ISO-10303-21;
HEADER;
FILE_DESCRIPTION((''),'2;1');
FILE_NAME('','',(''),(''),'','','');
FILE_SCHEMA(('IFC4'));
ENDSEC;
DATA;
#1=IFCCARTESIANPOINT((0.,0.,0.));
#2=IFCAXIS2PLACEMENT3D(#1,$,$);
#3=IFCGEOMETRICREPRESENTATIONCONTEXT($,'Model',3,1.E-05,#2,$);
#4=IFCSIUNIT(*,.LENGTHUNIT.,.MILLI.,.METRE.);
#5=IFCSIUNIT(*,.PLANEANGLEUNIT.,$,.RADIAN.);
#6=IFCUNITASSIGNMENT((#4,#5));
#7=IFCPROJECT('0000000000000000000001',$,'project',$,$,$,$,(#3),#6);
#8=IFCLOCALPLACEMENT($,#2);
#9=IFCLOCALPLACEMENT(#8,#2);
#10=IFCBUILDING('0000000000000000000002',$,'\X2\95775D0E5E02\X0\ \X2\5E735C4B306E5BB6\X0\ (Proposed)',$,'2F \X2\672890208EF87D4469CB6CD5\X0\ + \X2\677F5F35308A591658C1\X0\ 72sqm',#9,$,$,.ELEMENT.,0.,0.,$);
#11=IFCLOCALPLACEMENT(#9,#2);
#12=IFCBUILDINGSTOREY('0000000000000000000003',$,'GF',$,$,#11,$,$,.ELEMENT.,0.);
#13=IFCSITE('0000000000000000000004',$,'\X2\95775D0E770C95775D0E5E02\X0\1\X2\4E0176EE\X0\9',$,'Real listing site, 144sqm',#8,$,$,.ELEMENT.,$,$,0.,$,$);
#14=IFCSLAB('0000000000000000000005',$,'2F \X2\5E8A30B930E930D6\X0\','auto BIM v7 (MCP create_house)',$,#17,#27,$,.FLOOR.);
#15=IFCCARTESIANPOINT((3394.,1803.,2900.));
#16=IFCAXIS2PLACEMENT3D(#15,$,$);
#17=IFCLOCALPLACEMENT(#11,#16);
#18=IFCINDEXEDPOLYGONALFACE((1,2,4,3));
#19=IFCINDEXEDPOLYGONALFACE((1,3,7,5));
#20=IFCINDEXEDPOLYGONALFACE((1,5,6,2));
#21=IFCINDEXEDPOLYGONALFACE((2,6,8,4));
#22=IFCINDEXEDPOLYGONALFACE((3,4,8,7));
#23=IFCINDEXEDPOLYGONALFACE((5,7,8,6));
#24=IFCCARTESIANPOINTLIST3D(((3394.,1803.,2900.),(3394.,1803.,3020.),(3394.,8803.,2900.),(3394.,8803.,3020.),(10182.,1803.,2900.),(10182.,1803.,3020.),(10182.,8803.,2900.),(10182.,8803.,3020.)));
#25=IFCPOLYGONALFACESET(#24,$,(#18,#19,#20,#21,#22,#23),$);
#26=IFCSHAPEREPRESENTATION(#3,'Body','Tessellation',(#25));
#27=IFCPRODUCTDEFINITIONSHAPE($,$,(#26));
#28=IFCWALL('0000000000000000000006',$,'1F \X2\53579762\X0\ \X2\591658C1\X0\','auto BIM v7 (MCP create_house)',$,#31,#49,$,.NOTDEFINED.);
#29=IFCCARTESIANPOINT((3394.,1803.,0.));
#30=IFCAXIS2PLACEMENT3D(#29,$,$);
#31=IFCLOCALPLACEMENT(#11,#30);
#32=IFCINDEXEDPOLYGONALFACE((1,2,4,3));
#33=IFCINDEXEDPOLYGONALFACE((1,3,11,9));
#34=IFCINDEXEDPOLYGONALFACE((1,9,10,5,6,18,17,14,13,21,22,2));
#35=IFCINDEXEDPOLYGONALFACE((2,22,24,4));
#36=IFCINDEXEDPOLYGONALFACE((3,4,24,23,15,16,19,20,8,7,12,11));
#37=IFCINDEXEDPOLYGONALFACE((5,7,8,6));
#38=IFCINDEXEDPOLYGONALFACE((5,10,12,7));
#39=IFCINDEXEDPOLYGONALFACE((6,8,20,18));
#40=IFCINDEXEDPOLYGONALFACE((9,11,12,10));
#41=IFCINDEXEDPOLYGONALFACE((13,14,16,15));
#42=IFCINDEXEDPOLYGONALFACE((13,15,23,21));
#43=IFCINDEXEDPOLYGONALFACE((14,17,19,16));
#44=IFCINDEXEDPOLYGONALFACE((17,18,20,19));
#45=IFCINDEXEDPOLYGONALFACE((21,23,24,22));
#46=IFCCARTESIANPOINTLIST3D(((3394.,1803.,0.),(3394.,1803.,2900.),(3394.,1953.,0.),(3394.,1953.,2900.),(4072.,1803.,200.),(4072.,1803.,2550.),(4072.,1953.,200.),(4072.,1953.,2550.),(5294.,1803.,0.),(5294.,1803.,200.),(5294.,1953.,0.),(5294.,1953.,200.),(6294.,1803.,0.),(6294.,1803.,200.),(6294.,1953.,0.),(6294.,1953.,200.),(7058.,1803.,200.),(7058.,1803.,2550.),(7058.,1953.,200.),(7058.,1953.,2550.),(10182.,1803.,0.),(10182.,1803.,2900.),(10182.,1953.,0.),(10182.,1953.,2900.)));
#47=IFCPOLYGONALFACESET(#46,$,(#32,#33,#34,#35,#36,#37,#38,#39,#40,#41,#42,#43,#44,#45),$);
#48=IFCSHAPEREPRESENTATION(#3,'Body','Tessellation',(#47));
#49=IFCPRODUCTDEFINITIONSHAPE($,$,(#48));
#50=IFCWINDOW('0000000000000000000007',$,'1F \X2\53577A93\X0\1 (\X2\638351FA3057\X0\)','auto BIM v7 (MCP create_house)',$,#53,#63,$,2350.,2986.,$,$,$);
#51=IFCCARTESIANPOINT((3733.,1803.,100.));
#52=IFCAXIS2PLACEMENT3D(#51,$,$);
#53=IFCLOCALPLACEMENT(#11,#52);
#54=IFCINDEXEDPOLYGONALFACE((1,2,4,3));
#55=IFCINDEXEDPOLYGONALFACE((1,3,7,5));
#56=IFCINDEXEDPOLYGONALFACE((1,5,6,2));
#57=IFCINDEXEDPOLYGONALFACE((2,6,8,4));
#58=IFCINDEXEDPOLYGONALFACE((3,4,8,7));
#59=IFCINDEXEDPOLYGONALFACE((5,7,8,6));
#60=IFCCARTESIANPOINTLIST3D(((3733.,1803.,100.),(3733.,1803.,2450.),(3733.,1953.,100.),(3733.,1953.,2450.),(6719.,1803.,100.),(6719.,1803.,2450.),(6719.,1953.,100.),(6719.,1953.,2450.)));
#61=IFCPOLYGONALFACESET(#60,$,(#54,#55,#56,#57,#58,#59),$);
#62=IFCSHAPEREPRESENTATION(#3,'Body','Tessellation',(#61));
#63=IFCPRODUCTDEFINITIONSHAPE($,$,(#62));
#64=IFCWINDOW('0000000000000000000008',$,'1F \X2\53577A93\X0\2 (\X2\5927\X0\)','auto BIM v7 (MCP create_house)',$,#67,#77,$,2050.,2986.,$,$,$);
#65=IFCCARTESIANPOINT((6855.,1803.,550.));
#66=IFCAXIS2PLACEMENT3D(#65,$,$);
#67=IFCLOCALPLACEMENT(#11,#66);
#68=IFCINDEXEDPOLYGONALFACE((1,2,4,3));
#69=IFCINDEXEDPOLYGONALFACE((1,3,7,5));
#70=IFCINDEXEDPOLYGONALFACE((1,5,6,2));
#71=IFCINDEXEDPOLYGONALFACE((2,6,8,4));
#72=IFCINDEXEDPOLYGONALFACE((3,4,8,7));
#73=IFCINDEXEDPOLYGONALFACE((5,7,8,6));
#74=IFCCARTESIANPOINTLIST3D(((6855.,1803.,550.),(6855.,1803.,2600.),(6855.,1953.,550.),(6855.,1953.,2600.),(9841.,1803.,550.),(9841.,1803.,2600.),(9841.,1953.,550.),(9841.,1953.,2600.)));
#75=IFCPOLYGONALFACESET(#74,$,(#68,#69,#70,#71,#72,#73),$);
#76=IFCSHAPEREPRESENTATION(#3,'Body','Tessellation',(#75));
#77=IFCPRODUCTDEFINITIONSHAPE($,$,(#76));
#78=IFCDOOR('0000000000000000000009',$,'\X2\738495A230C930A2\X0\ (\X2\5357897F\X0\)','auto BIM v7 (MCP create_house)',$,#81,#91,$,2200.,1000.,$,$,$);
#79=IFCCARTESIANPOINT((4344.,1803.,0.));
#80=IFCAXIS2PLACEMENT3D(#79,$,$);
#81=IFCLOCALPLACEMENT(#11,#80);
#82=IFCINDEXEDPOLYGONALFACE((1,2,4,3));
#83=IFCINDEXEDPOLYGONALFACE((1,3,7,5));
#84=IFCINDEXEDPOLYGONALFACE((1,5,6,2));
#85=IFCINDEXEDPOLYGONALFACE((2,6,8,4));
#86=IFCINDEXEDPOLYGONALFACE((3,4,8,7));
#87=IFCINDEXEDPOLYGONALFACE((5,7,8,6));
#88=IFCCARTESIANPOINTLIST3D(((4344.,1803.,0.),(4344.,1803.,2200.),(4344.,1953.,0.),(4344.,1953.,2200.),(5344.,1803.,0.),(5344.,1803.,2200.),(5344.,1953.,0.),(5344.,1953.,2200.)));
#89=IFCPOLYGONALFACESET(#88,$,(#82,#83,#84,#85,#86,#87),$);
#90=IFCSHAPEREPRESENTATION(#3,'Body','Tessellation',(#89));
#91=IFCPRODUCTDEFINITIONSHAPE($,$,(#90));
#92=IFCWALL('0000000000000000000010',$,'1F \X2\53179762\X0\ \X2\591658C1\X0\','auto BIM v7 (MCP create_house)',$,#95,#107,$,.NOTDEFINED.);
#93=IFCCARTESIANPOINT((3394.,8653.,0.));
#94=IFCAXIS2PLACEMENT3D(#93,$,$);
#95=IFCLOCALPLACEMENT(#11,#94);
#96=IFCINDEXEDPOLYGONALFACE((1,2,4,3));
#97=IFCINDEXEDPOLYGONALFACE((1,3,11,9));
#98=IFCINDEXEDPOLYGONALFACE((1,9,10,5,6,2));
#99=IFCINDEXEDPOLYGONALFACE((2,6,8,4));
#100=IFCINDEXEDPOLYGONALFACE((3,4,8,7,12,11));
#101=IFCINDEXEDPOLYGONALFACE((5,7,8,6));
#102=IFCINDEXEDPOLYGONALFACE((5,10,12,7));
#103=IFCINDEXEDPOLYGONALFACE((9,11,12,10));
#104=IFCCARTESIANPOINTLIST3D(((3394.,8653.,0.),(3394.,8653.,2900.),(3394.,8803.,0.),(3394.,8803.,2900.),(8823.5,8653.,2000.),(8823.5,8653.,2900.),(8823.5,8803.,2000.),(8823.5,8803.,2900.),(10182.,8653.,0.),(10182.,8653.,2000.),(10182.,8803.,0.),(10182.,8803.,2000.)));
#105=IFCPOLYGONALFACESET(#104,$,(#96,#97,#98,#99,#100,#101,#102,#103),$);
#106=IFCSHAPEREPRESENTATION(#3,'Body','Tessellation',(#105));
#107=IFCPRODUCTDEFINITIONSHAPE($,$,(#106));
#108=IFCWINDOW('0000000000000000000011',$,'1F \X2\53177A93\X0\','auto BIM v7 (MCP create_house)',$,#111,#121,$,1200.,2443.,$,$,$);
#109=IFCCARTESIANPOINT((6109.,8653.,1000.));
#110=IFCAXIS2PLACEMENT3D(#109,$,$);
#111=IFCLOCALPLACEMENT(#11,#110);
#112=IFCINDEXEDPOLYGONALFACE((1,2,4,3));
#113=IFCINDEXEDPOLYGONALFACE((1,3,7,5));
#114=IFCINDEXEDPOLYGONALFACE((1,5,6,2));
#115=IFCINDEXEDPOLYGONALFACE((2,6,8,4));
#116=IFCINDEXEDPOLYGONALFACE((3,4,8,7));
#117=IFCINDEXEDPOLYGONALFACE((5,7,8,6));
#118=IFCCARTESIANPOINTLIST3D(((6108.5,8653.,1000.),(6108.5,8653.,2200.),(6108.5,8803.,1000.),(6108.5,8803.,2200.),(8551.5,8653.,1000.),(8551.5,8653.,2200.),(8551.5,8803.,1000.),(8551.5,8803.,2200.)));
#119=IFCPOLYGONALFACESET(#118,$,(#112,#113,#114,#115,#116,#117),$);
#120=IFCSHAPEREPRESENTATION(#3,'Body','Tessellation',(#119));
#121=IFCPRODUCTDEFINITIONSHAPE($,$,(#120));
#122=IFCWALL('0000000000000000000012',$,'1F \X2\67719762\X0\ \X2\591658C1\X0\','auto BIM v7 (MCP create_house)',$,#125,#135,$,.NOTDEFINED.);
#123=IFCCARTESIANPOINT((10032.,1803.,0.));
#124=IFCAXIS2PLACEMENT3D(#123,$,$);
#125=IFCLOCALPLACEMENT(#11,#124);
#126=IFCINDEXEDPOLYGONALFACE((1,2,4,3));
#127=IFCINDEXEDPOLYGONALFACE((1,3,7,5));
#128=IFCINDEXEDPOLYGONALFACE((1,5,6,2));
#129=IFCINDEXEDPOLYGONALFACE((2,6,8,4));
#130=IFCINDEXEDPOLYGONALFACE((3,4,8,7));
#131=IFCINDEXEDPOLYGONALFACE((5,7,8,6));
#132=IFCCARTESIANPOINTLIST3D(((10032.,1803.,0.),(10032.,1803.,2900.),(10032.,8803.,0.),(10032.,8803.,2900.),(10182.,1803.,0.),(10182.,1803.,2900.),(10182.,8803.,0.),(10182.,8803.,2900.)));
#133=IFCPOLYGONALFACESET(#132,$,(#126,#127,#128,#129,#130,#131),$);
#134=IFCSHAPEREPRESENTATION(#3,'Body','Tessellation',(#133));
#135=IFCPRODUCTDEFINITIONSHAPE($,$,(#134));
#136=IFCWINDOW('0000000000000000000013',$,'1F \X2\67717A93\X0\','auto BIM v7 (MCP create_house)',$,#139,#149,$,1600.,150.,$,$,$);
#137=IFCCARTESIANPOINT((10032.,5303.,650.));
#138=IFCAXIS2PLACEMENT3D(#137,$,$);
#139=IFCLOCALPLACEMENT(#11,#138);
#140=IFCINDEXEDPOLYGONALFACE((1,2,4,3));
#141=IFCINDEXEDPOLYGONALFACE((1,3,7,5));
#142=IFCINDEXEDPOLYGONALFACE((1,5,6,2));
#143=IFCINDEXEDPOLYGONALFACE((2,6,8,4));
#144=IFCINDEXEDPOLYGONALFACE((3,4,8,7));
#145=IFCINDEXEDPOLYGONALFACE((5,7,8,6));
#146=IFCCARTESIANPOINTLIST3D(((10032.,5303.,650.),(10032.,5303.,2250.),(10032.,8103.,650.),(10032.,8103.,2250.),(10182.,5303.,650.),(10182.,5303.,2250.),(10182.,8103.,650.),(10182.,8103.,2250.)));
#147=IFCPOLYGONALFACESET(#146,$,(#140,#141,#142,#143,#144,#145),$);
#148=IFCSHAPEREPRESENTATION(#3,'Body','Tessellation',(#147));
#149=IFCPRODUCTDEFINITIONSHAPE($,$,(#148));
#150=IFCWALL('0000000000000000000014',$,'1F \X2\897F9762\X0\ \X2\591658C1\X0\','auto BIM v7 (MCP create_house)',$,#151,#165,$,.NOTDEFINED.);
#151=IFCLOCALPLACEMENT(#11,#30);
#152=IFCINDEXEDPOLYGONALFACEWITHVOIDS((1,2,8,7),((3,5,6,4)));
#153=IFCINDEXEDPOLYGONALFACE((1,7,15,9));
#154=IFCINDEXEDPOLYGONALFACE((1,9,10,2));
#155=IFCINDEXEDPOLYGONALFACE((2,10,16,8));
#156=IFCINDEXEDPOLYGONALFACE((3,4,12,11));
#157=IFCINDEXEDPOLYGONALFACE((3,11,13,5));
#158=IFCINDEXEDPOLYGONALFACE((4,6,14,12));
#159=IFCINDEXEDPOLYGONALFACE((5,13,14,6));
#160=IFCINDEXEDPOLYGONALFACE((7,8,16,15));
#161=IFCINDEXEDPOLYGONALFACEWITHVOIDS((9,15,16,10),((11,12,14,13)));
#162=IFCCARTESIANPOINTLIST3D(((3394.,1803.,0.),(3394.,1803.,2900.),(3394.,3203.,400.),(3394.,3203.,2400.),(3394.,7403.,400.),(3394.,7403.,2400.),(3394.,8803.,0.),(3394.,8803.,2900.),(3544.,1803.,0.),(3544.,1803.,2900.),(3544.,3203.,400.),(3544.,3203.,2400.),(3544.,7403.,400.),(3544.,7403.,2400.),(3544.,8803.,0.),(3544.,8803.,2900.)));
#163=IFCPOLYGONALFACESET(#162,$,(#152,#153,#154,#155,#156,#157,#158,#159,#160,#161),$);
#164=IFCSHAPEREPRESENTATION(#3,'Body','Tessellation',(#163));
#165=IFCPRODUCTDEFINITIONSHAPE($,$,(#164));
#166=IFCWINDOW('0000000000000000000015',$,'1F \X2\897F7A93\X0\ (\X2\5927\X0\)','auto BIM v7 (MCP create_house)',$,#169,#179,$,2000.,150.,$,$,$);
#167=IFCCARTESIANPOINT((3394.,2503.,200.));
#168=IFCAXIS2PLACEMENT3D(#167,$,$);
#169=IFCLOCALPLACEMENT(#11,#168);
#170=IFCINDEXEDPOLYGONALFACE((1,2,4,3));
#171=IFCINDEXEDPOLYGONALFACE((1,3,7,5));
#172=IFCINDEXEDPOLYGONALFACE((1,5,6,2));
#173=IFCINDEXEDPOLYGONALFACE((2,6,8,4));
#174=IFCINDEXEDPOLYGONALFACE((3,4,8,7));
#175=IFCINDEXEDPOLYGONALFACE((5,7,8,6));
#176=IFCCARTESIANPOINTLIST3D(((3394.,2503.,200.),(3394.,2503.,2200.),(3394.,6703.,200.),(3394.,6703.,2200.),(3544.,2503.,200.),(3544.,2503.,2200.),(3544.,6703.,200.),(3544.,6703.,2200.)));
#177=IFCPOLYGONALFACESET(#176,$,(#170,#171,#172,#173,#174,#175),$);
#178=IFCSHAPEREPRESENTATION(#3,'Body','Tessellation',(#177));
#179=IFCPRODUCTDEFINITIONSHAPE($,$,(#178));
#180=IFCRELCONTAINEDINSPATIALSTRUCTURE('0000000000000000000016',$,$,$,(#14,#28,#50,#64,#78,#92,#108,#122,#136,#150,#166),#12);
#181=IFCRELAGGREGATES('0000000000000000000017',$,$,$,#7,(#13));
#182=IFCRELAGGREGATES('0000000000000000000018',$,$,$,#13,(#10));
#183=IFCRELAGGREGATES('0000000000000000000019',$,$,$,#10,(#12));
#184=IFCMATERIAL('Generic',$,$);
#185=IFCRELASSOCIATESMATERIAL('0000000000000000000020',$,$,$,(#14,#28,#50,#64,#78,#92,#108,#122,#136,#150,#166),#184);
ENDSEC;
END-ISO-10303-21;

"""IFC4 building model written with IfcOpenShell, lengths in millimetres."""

from ifc_helpers import new_model, si_unit, frame, frame_2d, origin, place, context, project, spatial, rectangle, extrude, material, element, fill, save


model = new_model("IFC4")

# Units and contexts
model_context = context("Model", 3, precision=1e-05, world=origin())
ifc_project = project(units=[si_unit("LENGTHUNIT", "METRE", prefix="MILLI"), si_unit("PLANEANGLEUNIT", "RADIAN")], contexts=[model_context])

# Site, building, storey
site_placement = place(None, origin())
site = spatial("IfcSite", under=ifc_project, at=site_placement, Name="長崎県長崎市1丁目9", ObjectType="Real listing site, 144sqm", CompositionType="ELEMENT", RefElevation=0.0)
building_placement = place(site_placement, origin())
building = spatial("IfcBuilding", under=site, at=building_placement, Name="長崎市 平屋の家 (Proposed)", ObjectType="2F 木造軸組構法 + 板張り外壁 72sqm", CompositionType="ELEMENT", ElevationOfRefHeight=0.0, ElevationOfTerrain=0.0)
storey_placement = place(building_placement, origin())
storey = spatial("IfcBuildingStorey", under=building, at=storey_placement, Name="GF", CompositionType="ELEMENT", Elevation=0.0)

# Slab
ifc_material = material(Name="Generic")
slab_1_placement = place(storey_placement, frame((3394.0, 1803.0, 2900.0)))
element("IfcSlab", 1, at=slab_1_placement, inside=storey, material=ifc_material, Name="2F 床スラブ", Description="auto BIM v7 (MCP create_house)", PredefinedType="FLOOR", context=model_context, shape_type="SweptSolid", body=[
    extrude(rectangle(XDim=6788.0, YDim=7000.0, at=frame_2d((3394.0, 3500.0))), frame((3394.0, 1803.0, 2900.0)), (0.0, 0.0, 1.0), 120.0),
])

# Wall, openings, windows, door
wall_1_placement = place(storey_placement, frame((3394.0, 1803.0, 0.0)))
wall_1 = element("IfcWall", 2, at=wall_1_placement, inside=storey, material=ifc_material, Name="1F 南面 外壁", Description="auto BIM v7 (MCP create_house)", PredefinedType="NOTDEFINED", context=model_context, shape_type="SweptSolid", body=[
    extrude(rectangle(XDim=6788.0, YDim=150.0, at=frame_2d((3394.0, 75.0))), frame((3394.0, 1803.0, 0.0)), (0.0, 0.0, 1.0), 2900.0),
])
opening_1_placement = place(storey_placement, frame((3733.0, 1803.0, 100.0)))
opening_1 = element("IfcOpeningElement", 3, at=opening_1_placement, cuts=wall_1, PredefinedType="NOTDEFINED", context=model_context, shape_type="SweptSolid", body=[
    extrude(rectangle(XDim=2986.0, YDim=150.0, at=frame_2d((1493.0, 75.0))), frame((3733.0, 1803.0, 100.0)), (0.0, 0.0, 1.0), 2350.0),
])
opening_2_placement = place(storey_placement, frame((6855.0, 1803.0, 550.0)))
opening_2 = element("IfcOpeningElement", 4, at=opening_2_placement, cuts=wall_1, PredefinedType="NOTDEFINED", context=model_context, shape_type="SweptSolid", body=[
    extrude(rectangle(XDim=2986.0, YDim=150.0, at=frame_2d((1493.0, 75.0))), frame((6855.0, 1803.0, 550.0)), (0.0, 0.0, 1.0), 2050.0),
])
opening_3_placement = place(storey_placement, frame((4344.0, 1803.0, 0.0)))
opening_3 = element("IfcOpeningElement", 5, at=opening_3_placement, cuts=wall_1, PredefinedType="NOTDEFINED", context=model_context, shape_type="SweptSolid", body=[
    extrude(rectangle(XDim=1000.0, YDim=150.0, at=frame_2d((500.0, 75.0))), frame((4344.0, 1803.0, 0.0)), (0.0, 0.0, 1.0), 2200.0),
])
window_1_placement = place(storey_placement, frame((3733.0, 1803.0, 100.0)))
window_1 = element("IfcWindow", 6, at=window_1_placement, inside=storey, material=ifc_material, Name="1F 南窓1 (掃出し)", Description="auto BIM v7 (MCP create_house)", OverallHeight=2350.0, OverallWidth=2986.0, context=model_context, shape_type="SweptSolid", body=[
    extrude(rectangle(XDim=2986.0, YDim=150.0, at=frame_2d((1493.0, 75.0))), frame((3733.0, 1803.0, 100.0)), (0.0, 0.0, 1.0), 2350.0),
])
fill(opening_1, window_1)
window_2_placement = place(storey_placement, frame((6855.0, 1803.0, 550.0)))
window_2 = element("IfcWindow", 7, at=window_2_placement, inside=storey, material=ifc_material, Name="1F 南窓2 (大)", Description="auto BIM v7 (MCP create_house)", OverallHeight=2050.0, OverallWidth=2986.0, context=model_context, shape_type="SweptSolid", body=[
    extrude(rectangle(XDim=2986.0, YDim=150.0, at=frame_2d((1493.0, 75.0))), frame((6855.0, 1803.0, 550.0)), (0.0, 0.0, 1.0), 2050.0),
])
fill(opening_2, window_2)
door_placement = place(storey_placement, frame((4344.0, 1803.0, 0.0)))
door = element("IfcDoor", 8, at=door_placement, inside=storey, material=ifc_material, Name="玄関ドア (南西)", Description="auto BIM v7 (MCP create_house)", OverallHeight=2200.0, OverallWidth=1000.0, context=model_context, shape_type="SweptSolid", body=[
    extrude(rectangle(XDim=1000.0, YDim=150.0, at=frame_2d((500.0, 75.0))), frame((4344.0, 1803.0, 0.0)), (0.0, 0.0, 1.0), 2200.0),
])
fill(opening_3, door)

# Walls, openings, windows
wall_2_placement = place(storey_placement, frame((3394.0, 8653.0, 0.0)))
wall_2 = element("IfcWall", 9, at=wall_2_placement, inside=storey, material=ifc_material, Name="1F 北面 外壁", Description="auto BIM v7 (MCP create_house)", PredefinedType="NOTDEFINED", context=model_context, shape_type="SweptSolid", body=[
    extrude(rectangle(XDim=6788.0, YDim=150.0, at=frame_2d((3394.0, 75.0))), frame((3394.0, 8653.0, 0.0)), (0.0, 0.0, 1.0), 2900.0),
])
opening_4_placement = place(storey_placement, frame((6109.0, 8653.0, 1000.0)))
opening_4 = element("IfcOpeningElement", 10, at=opening_4_placement, cuts=wall_2, PredefinedType="NOTDEFINED", context=model_context, shape_type="SweptSolid", body=[
    extrude(rectangle(XDim=2443.0, YDim=150.0, at=frame_2d((1221.0, 75.0))), frame((6109.0, 8653.0, 1000.0)), (0.0, 0.0, 1.0), 1200.0),
])
window_3_placement = place(storey_placement, frame((6109.0, 8653.0, 1000.0)))
window_3 = element("IfcWindow", 11, at=window_3_placement, inside=storey, material=ifc_material, Name="1F 北窓", Description="auto BIM v7 (MCP create_house)", OverallHeight=1200.0, OverallWidth=2443.0, context=model_context, shape_type="SweptSolid", body=[
    extrude(rectangle(XDim=2443.0, YDim=150.0, at=frame_2d((1221.0, 75.0))), frame((6109.0, 8653.0, 1000.0)), (0.0, 0.0, 1.0), 1200.0),
])
fill(opening_4, window_3)
wall_3_placement = place(storey_placement, frame((10032.0, 1803.0, 0.0)))
wall_3 = element("IfcWall", 12, at=wall_3_placement, inside=storey, material=ifc_material, Name="1F 東面 外壁", Description="auto BIM v7 (MCP create_house)", PredefinedType="NOTDEFINED", context=model_context, shape_type="SweptSolid", body=[
    extrude(rectangle(XDim=150.0, YDim=7000.0, at=frame_2d((75.0, 3500.0))), frame((10032.0, 1803.0, 0.0)), (0.0, 0.0, 1.0), 2900.0),
])
opening_5_placement = place(storey_placement, frame((10032.0, 5303.0, 650.0)))
opening_5 = element("IfcOpeningElement", 13, at=opening_5_placement, cuts=wall_3, PredefinedType="NOTDEFINED", context=model_context, shape_type="SweptSolid", body=[
    extrude(rectangle(XDim=150.0, YDim=2800.0, at=frame_2d((75.0, 1400.0))), frame((10032.0, 5303.0, 650.0)), (0.0, 0.0, 1.0), 1600.0),
])
window_4_placement = place(storey_placement, frame((10032.0, 5303.0, 650.0)))
window_4 = element("IfcWindow", 14, at=window_4_placement, inside=storey, material=ifc_material, Name="1F 東窓", Description="auto BIM v7 (MCP create_house)", OverallHeight=1600.0, OverallWidth=150.0, context=model_context, shape_type="SweptSolid", body=[
    extrude(rectangle(XDim=150.0, YDim=2800.0, at=frame_2d((75.0, 1400.0))), frame((10032.0, 5303.0, 650.0)), (0.0, 0.0, 1.0), 1600.0),
])
fill(opening_5, window_4)
wall_4_placement = place(storey_placement, frame((3394.0, 1803.0, 0.0)))
wall_4 = element("IfcWall", 15, at=wall_4_placement, inside=storey, material=ifc_material, Name="1F 西面 外壁", Description="auto BIM v7 (MCP create_house)", PredefinedType="NOTDEFINED", context=model_context, shape_type="SweptSolid", body=[
    extrude(rectangle(XDim=150.0, YDim=7000.0, at=frame_2d((75.0, 3500.0))), frame((3394.0, 1803.0, 0.0)), (0.0, 0.0, 1.0), 2900.0),
])
opening_6_placement = place(storey_placement, frame((3394.0, 2503.0, 200.0)))
opening_6 = element("IfcOpeningElement", 16, at=opening_6_placement, cuts=wall_4, PredefinedType="NOTDEFINED", context=model_context, shape_type="SweptSolid", body=[
    extrude(rectangle(XDim=150.0, YDim=4200.0, at=frame_2d((75.0, 2100.0))), frame((3394.0, 2503.0, 200.0)), (0.0, 0.0, 1.0), 2000.0),
])
window_5_placement = place(storey_placement, frame((3394.0, 2503.0, 200.0)))
window_5 = element("IfcWindow", 17, at=window_5_placement, inside=storey, material=ifc_material, Name="1F 西窓 (大)", Description="auto BIM v7 (MCP create_house)", OverallHeight=2000.0, OverallWidth=150.0, context=model_context, shape_type="SweptSolid", body=[
    extrude(rectangle(XDim=150.0, YDim=4200.0, at=frame_2d((75.0, 2100.0))), frame((3394.0, 2503.0, 200.0)), (0.0, 0.0, 1.0), 2000.0),
])
fill(opening_6, window_5)

save(model, "model.ifc")
